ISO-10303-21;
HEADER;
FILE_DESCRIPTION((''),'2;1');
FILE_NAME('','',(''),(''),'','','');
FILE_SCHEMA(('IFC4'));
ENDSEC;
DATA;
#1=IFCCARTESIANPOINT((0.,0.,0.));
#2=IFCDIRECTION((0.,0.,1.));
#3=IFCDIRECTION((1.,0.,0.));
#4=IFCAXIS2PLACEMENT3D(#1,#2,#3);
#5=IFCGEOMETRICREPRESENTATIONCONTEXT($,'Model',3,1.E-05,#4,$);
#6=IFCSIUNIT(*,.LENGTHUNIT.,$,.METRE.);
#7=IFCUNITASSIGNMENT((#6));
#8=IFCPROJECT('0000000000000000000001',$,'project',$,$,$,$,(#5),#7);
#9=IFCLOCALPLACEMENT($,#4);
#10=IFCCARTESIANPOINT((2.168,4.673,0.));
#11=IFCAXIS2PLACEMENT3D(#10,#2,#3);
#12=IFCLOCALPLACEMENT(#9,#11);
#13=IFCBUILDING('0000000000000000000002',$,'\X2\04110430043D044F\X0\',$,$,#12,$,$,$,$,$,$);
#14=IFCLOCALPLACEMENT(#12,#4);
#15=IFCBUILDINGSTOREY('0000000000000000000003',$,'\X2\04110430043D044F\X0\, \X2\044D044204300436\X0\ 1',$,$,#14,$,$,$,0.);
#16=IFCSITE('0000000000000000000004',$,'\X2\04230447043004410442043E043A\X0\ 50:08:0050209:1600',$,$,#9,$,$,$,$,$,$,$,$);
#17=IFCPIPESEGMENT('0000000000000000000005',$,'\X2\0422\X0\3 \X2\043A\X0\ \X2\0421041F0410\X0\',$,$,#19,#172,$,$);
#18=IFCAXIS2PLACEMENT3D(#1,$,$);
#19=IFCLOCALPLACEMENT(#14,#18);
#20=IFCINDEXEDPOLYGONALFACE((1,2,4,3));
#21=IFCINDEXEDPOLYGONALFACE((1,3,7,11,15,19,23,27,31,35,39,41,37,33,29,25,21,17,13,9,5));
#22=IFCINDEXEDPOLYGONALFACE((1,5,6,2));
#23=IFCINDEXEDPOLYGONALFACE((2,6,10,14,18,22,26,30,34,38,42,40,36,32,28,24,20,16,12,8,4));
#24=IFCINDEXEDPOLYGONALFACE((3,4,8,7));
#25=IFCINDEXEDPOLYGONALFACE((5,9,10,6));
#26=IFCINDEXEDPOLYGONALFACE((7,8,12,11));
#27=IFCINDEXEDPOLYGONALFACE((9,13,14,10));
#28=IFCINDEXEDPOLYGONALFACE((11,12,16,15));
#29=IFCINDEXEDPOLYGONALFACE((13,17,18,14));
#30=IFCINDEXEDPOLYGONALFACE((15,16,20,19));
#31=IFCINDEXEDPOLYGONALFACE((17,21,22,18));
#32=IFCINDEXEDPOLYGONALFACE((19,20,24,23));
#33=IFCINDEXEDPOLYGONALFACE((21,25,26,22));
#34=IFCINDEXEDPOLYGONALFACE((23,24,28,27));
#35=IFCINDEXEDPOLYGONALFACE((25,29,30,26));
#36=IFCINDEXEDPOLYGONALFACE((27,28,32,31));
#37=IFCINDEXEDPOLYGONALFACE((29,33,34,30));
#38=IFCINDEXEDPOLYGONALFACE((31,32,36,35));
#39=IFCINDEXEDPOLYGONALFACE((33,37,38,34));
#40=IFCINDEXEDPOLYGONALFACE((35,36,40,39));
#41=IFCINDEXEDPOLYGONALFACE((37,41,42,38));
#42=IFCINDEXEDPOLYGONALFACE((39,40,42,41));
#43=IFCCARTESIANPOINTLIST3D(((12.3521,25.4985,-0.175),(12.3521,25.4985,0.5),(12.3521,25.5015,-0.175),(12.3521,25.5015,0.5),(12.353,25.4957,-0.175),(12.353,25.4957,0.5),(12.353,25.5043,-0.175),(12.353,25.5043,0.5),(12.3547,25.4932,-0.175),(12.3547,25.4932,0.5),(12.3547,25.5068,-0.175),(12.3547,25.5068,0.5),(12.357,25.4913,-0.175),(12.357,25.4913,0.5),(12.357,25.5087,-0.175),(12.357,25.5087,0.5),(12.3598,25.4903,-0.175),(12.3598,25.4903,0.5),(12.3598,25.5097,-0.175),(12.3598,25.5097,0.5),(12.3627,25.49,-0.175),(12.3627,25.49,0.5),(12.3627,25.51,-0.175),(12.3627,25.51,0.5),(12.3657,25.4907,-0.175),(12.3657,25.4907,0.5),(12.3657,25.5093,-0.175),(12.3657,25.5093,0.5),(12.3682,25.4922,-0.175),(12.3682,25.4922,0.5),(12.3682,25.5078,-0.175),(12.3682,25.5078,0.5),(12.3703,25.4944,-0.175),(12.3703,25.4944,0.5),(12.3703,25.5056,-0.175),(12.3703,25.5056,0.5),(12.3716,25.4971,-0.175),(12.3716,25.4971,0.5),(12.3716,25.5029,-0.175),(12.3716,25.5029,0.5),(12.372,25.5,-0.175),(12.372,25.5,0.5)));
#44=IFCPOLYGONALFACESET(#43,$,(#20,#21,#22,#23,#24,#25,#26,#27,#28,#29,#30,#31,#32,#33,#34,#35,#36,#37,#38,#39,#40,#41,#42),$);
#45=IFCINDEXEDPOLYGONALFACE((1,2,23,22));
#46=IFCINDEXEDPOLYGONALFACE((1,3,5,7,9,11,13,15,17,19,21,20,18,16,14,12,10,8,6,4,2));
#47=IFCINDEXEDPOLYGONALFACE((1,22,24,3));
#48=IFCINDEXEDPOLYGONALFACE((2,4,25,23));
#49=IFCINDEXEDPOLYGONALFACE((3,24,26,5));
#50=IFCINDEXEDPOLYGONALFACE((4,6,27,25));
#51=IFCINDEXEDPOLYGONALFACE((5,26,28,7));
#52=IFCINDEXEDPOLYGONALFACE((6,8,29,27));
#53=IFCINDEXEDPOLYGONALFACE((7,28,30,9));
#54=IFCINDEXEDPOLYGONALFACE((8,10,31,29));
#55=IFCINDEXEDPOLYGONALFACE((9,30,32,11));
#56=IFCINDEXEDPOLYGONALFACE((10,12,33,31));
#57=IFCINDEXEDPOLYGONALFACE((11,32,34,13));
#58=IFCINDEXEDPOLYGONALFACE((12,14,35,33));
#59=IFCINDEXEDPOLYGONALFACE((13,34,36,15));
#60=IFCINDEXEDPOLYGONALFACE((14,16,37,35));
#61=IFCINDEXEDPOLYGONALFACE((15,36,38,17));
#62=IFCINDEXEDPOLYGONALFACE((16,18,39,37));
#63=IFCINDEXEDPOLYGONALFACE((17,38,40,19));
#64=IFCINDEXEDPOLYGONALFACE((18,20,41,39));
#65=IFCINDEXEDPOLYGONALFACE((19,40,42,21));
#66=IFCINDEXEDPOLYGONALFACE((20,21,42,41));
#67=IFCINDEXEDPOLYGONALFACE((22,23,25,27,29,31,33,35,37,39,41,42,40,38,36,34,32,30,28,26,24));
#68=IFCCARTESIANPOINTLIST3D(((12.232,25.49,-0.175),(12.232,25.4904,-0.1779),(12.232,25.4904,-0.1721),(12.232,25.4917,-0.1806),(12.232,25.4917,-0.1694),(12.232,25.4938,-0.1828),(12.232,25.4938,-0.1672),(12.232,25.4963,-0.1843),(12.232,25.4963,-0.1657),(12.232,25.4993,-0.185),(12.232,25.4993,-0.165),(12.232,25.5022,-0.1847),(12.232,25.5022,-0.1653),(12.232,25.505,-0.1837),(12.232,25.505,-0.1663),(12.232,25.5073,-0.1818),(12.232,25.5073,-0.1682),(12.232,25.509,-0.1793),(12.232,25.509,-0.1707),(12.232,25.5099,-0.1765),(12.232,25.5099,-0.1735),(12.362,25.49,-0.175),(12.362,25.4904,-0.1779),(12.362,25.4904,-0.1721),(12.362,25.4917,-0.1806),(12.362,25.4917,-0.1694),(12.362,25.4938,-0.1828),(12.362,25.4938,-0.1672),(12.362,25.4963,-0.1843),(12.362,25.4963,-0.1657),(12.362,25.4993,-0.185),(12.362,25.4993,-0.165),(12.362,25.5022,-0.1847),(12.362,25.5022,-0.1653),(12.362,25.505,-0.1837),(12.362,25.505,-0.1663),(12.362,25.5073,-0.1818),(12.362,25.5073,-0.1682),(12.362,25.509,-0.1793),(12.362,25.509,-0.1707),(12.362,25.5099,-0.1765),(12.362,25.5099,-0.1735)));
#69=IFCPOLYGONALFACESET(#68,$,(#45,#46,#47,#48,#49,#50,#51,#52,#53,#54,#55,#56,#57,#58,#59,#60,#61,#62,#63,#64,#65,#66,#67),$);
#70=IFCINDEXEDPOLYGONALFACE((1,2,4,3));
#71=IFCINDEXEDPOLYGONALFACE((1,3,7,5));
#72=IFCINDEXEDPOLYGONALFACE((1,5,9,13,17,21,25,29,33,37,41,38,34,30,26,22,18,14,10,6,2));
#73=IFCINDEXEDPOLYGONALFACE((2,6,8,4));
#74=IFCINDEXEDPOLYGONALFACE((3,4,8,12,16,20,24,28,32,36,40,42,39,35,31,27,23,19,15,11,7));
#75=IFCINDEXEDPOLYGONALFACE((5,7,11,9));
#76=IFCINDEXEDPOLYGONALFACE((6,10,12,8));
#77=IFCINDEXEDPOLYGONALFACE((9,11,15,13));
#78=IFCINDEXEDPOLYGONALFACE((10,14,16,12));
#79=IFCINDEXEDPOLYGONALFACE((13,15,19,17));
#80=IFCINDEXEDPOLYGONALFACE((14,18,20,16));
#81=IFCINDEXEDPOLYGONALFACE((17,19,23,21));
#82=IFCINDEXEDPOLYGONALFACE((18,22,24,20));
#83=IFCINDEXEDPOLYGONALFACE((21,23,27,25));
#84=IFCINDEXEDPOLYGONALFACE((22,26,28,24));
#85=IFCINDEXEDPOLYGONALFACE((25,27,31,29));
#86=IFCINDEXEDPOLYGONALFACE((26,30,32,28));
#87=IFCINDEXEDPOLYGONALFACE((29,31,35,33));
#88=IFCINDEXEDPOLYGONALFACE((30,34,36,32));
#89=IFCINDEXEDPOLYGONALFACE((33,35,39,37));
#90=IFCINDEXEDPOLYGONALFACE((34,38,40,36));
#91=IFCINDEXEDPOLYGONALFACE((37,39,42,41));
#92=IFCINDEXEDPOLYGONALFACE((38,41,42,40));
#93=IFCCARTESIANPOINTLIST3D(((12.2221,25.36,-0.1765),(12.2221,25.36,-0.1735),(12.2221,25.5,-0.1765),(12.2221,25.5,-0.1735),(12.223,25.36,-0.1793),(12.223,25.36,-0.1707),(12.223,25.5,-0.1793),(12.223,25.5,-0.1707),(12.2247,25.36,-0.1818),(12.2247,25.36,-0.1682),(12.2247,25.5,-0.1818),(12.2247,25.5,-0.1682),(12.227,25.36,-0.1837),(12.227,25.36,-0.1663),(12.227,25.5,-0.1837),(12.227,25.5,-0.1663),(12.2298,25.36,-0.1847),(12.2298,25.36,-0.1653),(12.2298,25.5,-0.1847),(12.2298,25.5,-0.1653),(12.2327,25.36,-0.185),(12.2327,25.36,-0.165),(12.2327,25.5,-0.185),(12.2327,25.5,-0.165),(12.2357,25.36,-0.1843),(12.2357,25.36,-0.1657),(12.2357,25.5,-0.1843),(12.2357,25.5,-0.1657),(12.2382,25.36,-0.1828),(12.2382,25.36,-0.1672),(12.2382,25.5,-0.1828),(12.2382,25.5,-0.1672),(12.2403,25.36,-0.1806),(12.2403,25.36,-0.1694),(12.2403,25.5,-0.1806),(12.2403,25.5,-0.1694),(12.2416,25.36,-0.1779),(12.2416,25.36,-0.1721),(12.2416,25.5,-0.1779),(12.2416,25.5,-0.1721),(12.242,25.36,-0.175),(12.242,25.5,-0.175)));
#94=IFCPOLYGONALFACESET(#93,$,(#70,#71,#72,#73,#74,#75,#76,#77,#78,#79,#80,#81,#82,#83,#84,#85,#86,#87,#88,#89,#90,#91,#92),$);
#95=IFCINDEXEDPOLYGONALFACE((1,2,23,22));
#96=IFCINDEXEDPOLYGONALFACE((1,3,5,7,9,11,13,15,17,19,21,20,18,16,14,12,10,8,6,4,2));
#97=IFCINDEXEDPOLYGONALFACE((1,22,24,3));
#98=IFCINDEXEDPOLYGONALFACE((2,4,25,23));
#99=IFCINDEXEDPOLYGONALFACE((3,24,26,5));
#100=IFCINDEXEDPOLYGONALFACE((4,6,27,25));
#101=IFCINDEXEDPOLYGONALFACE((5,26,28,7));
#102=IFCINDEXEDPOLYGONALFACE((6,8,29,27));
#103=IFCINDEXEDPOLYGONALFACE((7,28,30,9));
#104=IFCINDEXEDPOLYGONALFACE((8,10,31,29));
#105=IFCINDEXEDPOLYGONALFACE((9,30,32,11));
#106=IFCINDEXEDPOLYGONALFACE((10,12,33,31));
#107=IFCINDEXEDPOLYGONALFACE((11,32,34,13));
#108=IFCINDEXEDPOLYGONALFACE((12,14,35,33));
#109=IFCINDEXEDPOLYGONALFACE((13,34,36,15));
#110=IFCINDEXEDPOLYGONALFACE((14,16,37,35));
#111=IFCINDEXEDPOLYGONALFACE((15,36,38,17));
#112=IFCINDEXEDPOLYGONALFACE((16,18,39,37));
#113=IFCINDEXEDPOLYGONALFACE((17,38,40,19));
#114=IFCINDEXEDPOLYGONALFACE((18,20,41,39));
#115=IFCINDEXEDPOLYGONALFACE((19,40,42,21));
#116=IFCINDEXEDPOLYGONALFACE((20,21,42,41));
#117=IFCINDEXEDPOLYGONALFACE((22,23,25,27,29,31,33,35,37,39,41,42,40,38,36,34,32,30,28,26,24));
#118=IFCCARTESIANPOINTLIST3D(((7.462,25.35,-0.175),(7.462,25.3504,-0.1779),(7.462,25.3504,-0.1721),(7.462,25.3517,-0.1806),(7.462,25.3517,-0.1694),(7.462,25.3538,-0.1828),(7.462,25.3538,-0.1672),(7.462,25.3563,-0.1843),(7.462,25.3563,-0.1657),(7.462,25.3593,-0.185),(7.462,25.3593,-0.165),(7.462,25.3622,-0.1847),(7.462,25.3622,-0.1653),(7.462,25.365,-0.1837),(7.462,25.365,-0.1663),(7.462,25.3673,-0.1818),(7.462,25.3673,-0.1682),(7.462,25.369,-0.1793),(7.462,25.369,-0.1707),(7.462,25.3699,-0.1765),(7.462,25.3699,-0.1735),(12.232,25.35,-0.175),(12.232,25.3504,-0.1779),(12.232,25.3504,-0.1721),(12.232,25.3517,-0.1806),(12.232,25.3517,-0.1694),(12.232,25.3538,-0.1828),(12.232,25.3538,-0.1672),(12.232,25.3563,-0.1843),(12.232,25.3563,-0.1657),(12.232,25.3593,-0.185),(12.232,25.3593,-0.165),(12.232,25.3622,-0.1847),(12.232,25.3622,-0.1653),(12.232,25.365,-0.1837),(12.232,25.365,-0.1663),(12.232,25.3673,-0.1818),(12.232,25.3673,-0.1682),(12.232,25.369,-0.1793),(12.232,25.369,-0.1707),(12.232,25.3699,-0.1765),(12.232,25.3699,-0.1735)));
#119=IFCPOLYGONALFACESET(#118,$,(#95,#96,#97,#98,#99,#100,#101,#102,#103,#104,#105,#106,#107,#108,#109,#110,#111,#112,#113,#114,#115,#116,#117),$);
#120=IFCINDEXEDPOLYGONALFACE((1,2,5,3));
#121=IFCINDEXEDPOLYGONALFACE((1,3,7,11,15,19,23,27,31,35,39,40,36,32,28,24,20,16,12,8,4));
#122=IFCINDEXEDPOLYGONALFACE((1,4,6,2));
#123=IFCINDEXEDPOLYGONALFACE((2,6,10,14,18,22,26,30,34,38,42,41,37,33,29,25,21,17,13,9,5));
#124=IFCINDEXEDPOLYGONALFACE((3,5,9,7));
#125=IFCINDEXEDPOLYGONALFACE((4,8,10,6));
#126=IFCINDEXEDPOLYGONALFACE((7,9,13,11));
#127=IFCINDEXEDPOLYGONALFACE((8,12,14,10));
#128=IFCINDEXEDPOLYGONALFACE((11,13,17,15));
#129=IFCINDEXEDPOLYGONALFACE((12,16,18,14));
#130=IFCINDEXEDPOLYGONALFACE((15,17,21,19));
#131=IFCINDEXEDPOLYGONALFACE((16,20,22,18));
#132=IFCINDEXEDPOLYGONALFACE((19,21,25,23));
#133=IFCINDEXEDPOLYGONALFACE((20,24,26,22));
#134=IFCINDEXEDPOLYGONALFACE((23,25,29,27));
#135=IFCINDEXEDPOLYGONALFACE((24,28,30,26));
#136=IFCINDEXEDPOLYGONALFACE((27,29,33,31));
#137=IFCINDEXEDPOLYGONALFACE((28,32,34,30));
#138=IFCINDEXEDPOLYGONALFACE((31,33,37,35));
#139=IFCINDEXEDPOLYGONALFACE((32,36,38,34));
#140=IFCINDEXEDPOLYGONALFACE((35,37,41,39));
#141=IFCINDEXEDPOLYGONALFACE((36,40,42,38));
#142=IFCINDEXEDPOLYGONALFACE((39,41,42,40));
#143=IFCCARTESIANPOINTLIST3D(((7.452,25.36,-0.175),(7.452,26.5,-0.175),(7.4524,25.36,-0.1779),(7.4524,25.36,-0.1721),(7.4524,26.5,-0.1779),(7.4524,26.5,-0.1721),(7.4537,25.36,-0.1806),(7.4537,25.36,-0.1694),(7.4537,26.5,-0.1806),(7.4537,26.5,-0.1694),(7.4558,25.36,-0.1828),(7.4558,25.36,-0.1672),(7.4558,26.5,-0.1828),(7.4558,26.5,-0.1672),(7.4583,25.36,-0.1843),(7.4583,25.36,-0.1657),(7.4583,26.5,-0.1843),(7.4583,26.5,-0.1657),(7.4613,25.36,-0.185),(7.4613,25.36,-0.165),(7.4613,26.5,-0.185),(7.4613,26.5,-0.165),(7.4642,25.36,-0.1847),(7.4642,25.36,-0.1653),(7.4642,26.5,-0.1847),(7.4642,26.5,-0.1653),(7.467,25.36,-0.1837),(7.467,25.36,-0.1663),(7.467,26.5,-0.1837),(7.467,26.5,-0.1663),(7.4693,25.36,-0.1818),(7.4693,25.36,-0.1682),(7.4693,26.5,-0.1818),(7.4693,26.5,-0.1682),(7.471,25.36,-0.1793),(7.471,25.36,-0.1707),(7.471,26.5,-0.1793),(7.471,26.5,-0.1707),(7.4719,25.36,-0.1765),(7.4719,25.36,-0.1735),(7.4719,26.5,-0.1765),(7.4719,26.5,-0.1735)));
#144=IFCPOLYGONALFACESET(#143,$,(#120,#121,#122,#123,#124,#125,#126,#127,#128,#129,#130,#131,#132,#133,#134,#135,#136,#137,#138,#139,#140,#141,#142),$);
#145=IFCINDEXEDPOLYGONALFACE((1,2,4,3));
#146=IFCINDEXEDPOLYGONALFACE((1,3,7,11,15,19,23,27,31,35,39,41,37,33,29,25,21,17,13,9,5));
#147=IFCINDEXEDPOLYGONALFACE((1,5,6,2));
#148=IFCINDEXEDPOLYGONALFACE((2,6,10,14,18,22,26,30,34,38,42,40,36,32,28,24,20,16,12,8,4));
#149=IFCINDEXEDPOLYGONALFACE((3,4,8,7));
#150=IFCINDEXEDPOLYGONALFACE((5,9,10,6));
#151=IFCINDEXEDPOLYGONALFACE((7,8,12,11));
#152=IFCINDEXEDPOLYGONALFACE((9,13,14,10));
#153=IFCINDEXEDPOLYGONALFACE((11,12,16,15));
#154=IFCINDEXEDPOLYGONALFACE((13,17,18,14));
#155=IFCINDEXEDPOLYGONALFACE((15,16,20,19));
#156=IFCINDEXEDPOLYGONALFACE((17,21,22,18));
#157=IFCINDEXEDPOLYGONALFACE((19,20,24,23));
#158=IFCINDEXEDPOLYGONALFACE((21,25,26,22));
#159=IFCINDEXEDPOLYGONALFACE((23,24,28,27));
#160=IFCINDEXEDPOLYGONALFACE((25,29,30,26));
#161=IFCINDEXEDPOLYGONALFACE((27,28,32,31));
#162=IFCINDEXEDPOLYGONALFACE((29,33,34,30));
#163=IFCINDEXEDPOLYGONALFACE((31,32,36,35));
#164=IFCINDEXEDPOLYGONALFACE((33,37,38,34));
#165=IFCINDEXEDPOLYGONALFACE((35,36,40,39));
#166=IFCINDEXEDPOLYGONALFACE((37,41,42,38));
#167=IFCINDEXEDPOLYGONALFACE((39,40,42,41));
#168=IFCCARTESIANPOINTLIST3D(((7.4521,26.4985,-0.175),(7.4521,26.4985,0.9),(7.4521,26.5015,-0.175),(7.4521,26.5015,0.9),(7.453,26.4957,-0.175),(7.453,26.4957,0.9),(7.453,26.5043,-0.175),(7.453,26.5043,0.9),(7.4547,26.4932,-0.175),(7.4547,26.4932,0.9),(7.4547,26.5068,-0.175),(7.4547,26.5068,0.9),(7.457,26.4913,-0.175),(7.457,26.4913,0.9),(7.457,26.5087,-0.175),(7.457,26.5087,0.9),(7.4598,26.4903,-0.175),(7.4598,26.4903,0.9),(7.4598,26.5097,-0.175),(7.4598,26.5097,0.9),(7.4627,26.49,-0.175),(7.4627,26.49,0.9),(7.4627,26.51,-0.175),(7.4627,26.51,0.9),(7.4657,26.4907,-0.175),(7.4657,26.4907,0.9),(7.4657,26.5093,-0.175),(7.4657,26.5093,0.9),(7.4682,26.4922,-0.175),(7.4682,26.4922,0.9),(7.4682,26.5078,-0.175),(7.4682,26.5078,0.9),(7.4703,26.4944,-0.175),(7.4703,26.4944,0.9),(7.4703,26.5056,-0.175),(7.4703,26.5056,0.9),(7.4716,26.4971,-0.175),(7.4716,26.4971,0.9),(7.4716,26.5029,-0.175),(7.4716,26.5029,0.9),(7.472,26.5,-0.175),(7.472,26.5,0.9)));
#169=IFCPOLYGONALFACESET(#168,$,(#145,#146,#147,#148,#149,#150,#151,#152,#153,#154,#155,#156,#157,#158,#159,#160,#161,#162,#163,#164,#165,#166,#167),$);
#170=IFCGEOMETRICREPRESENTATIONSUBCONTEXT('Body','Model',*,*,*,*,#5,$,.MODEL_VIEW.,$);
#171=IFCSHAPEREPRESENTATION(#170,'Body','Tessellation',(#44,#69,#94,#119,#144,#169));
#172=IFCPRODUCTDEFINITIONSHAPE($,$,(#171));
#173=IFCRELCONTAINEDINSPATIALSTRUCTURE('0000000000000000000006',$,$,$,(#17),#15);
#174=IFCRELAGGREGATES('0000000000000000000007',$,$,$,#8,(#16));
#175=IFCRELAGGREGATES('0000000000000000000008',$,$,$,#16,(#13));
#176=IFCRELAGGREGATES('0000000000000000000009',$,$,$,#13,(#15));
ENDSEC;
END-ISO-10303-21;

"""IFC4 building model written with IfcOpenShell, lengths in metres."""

from ifc_helpers import new_model, si_unit, frame, origin_with_axes, origin_2d, place, context, subcontext, project, spatial, circle, extrude, element, save


model = new_model("IFC4")

# Units and contexts
model_context = context("Model", 3, precision=1e-05, world=origin_with_axes())
body_context = subcontext(model_context, "Body", "Model", "MODEL_VIEW")
ifc_project = project(units=[si_unit("LENGTHUNIT", "METRE")], contexts=[model_context])

# Site, building, storey
site_placement = place(None, origin_with_axes())
site = spatial("IfcSite", under=ifc_project, at=site_placement, Name="Участок 50:08:0050209:1600")
building_placement = place(site_placement, frame((2.168, 4.673, 0.0), z_axis=(0.0, 0.0, 1.0), x_axis=(1.0, 0.0, 0.0)))
building = spatial("IfcBuilding", under=site, at=building_placement, Name="Баня")
storey_placement = place(building_placement, origin_with_axes())
storey = spatial("IfcBuildingStorey", under=building, at=storey_placement, Name="Баня, этаж 1", Elevation=0.0)

# Pipe segment
pipe_segment_1_placement = place(storey_placement, origin_with_axes())
element("IfcPipeSegment", 1, at=pipe_segment_1_placement, inside=storey, Name="Т3 к СПА", context=body_context, shape_type="SweptSolid", body=[
    extrude(circle(Radius=0.01, at=origin_2d()), frame((12.362, 25.5, 0.5), z_axis=(0.0, 0.0, -1.0), x_axis=(1.0, 0.0, 0.0)), (0.0, 0.0, 1.0), 0.675),
    extrude(circle(Radius=0.01, at=origin_2d()), frame((12.362, 25.5, -0.175), z_axis=(-1.0, 0.0, 0.0), x_axis=(0.0, -1.0, 0.0)), (0.0, 0.0, 1.0), 0.13),
    extrude(circle(Radius=0.01, at=origin_2d()), frame((12.232, 25.5, -0.175), z_axis=(0.0, -1.0, 0.0), x_axis=(1.0, 0.0, 0.0)), (0.0, 0.0, 1.0), 0.14),
    extrude(circle(Radius=0.01, at=origin_2d()), frame((12.232, 25.36, -0.175), z_axis=(-1.0, 0.0, 0.0), x_axis=(0.0, -1.0, 0.0)), (0.0, 0.0, 1.0), 4.77),
    extrude(circle(Radius=0.01, at=origin_2d()), frame((7.462, 25.36, -0.175), z_axis=(0.0, 1.0, 0.0), x_axis=(-1.0, 0.0, 0.0)), (0.0, 0.0, 1.0), 1.14),
    extrude(circle(Radius=0.01, at=origin_2d()), frame((7.462, 26.5, -0.175), z_axis=(0.0, 0.0, 1.0), x_axis=(1.0, 0.0, 0.0)), (0.0, 0.0, 1.0), 1.075),
])

save(model, "model.ifc")
